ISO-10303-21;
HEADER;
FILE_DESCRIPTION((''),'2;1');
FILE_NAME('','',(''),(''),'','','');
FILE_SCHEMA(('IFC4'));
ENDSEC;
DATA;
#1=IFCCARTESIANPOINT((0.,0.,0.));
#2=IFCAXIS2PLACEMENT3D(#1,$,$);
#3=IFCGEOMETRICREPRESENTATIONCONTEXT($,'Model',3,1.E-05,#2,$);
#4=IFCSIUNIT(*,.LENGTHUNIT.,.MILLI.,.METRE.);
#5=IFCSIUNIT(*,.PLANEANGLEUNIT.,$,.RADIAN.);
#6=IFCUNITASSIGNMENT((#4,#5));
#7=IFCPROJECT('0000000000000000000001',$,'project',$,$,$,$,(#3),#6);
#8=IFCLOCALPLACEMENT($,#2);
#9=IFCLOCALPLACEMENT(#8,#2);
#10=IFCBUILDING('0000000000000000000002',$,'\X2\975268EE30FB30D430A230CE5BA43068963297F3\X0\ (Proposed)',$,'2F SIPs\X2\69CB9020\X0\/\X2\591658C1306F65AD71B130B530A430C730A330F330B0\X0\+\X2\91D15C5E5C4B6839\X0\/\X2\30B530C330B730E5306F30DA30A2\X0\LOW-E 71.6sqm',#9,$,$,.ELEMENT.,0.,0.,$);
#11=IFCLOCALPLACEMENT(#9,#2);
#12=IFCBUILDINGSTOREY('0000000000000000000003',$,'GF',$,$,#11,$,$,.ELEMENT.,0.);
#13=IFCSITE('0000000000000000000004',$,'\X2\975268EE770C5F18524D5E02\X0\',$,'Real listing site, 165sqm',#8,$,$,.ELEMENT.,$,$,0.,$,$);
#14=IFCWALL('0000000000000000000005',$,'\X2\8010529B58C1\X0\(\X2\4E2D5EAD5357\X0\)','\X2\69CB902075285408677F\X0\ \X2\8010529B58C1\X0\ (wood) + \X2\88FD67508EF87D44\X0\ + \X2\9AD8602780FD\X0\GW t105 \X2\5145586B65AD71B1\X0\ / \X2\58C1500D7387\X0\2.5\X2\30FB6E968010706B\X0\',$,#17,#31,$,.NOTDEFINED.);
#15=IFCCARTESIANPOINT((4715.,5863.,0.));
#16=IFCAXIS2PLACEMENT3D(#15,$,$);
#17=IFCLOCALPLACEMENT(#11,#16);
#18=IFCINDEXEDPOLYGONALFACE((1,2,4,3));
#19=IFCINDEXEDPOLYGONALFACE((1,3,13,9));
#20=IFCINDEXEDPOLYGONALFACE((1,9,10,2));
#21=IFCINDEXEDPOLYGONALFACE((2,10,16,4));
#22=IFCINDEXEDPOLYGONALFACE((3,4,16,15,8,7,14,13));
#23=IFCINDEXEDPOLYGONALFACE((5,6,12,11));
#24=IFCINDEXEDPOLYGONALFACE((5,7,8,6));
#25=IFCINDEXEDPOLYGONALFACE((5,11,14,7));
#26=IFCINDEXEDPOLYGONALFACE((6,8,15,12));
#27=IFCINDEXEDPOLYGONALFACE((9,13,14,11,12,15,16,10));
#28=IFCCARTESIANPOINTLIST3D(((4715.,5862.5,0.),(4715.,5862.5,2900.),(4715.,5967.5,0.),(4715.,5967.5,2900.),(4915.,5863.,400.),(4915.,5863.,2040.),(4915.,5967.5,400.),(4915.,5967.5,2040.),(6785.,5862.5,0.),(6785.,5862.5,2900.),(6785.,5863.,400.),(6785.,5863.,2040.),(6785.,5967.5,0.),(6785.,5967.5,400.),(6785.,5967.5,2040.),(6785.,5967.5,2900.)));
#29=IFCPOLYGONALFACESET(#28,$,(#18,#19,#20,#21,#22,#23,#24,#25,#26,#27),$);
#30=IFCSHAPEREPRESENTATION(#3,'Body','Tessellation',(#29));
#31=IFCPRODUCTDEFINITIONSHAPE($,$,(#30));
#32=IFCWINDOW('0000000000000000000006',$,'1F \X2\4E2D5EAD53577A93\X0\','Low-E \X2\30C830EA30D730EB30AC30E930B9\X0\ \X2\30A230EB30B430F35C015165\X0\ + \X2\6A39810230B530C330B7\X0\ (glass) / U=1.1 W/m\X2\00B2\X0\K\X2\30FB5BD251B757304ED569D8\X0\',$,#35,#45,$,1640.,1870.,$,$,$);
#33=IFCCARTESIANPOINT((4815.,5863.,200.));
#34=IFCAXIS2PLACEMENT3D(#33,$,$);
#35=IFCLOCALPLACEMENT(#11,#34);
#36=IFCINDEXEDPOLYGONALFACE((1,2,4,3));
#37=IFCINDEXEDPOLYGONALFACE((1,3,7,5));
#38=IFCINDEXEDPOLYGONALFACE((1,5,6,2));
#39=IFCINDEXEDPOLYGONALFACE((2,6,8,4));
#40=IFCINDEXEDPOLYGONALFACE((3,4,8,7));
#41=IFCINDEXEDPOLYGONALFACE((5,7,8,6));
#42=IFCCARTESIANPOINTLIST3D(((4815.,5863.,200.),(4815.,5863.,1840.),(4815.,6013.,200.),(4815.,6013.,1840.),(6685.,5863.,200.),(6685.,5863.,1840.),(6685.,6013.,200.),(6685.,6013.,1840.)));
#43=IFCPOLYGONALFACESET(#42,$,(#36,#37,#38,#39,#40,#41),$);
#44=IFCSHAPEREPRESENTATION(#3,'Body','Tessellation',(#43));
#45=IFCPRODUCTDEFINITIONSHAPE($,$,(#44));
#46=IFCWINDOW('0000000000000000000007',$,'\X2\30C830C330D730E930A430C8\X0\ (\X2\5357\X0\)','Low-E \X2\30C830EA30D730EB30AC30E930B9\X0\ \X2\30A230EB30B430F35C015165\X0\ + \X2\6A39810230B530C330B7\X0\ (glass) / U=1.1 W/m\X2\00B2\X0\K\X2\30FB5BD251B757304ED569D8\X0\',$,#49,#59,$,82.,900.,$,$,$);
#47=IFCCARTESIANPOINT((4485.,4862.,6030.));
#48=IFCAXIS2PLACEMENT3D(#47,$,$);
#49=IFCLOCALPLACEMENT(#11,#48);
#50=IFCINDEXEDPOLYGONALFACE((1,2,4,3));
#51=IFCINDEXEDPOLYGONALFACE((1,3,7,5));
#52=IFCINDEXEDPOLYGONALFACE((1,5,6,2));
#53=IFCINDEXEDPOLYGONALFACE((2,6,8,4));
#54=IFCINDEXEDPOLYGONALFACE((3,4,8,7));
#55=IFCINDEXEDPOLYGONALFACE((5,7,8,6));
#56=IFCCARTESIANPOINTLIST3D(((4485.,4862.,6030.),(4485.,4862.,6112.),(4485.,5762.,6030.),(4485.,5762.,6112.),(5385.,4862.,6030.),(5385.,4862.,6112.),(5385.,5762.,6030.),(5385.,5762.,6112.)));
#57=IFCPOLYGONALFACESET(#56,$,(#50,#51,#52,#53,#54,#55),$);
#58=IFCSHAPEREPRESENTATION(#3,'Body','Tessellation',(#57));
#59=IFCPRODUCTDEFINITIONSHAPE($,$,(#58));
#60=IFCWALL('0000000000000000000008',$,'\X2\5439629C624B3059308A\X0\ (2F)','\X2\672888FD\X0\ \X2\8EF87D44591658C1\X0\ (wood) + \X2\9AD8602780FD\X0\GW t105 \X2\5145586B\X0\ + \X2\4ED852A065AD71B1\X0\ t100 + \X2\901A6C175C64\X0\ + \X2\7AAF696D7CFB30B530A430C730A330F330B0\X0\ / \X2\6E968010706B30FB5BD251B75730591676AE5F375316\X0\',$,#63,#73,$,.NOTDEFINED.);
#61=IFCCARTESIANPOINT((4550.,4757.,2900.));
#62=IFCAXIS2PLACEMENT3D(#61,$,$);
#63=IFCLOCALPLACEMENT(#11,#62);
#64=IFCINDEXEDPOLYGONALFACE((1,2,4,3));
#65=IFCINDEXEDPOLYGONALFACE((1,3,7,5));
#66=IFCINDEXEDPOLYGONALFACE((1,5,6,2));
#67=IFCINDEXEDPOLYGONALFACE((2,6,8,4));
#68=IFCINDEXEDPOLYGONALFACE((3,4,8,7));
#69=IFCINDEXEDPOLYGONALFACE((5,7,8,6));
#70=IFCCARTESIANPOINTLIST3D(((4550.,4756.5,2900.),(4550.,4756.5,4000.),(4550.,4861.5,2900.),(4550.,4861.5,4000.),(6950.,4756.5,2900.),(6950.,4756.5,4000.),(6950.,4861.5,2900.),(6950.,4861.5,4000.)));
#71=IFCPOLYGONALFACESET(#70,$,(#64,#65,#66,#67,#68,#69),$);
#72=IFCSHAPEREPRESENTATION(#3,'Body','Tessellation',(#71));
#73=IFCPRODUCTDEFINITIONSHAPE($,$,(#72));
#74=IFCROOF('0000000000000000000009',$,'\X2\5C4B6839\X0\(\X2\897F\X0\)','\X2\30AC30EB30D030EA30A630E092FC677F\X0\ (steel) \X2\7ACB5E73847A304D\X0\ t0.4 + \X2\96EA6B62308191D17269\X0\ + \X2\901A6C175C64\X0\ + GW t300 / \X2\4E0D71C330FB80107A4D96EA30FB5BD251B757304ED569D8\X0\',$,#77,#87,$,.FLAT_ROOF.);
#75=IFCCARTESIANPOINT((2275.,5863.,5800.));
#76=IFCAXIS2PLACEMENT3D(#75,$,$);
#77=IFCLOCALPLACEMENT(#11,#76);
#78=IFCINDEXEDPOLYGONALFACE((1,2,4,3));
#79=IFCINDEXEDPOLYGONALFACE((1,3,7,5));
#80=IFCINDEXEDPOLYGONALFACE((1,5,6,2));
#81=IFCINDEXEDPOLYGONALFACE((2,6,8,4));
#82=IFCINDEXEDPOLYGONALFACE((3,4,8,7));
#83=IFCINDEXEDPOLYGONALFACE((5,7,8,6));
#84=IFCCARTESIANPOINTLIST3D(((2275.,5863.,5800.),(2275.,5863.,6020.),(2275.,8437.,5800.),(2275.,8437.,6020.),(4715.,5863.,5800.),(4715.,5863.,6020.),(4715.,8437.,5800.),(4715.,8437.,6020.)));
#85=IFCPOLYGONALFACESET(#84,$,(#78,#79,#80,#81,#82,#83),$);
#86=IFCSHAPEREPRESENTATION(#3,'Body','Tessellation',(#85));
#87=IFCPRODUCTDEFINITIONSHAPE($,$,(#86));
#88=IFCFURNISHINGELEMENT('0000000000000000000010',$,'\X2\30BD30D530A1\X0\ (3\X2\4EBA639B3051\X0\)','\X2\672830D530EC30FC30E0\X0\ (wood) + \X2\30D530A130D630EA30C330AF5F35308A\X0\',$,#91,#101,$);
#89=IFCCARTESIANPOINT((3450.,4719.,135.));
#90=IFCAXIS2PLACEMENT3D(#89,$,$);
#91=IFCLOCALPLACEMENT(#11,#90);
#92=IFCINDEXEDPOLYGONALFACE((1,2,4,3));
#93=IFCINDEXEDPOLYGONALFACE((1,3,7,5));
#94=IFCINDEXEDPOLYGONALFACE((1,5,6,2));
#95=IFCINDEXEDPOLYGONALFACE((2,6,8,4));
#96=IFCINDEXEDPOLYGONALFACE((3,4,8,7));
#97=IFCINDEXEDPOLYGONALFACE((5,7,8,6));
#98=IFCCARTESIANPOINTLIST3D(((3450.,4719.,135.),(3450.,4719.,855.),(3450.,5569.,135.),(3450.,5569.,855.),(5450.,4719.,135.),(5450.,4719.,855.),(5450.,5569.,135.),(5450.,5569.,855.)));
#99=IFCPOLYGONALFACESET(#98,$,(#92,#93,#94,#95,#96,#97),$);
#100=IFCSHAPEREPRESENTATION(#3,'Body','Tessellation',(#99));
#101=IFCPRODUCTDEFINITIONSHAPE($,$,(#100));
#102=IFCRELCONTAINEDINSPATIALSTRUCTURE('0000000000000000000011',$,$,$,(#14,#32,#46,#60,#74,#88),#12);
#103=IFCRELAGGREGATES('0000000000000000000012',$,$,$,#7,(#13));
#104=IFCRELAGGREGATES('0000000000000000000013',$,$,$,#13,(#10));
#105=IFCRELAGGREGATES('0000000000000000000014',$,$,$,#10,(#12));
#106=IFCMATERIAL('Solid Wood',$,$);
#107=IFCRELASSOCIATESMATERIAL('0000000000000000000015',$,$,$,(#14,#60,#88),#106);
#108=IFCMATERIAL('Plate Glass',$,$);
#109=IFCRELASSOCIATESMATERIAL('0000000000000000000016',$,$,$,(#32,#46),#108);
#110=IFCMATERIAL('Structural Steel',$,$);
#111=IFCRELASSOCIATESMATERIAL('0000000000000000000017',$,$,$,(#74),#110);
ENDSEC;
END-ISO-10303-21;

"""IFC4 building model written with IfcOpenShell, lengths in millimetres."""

from ifc_helpers import new_model, si_unit, frame, frame_2d, origin, place, context, project, spatial, rectangle, extrude, material, element, fill, save


model = new_model("IFC4")

# Units and contexts
model_context = context("Model", 3, precision=1e-05, world=origin())
ifc_project = project(units=[si_unit("LENGTHUNIT", "METRE", prefix="MILLI"), si_unit("PLANEANGLEUNIT", "RADIAN")], contexts=[model_context])

# Site, building, storey
site_placement = place(None, origin())
site = spatial("IfcSite", under=ifc_project, at=site_placement, Name="青森県弘前市", ObjectType="Real listing site, 165sqm", CompositionType="ELEMENT", RefElevation=0.0)
building_placement = place(site_placement, origin())
building = spatial("IfcBuilding", under=site, at=building_placement, Name="青森・ピアノ室と防音 (Proposed)", ObjectType="2F SIPs構造/外壁は断熱サイディング+金属屋根/サッシュはペアLOW-E 71.6sqm", CompositionType="ELEMENT", ElevationOfRefHeight=0.0, ElevationOfTerrain=0.0)
storey_placement = place(building_placement, origin())
storey = spatial("IfcBuildingStorey", under=building, at=storey_placement, Name="GF", CompositionType="ELEMENT", Elevation=0.0)

# Shared definitions
ifc_material_1 = material(Name="Solid Wood")

# Wall, opening, window
wall_1_placement = place(storey_placement, frame((4715.0, 5863.0, 0.0)))
wall_1 = element("IfcWall", 1, at=wall_1_placement, inside=storey, material=ifc_material_1, Name="耐力壁(中庭南)", Description="構造用合板 耐力壁 (wood) + 製材軸組 + 高性能GW t105 充填断熱 / 壁倍率2.5・準耐火", PredefinedType="NOTDEFINED", context=model_context, shape_type="SweptSolid", body=[
    extrude(rectangle(XDim=2070.0, YDim=105.0, at=frame_2d((1035.0, 52.0))), frame((4715.0, 5863.0, 0.0)), (0.0, 0.0, 1.0), 2900.0),
])
opening_placement = place(storey_placement, frame((4815.0, 5863.0, 200.0)))
opening = element("IfcOpeningElement", 2, at=opening_placement, cuts=wall_1, PredefinedType="NOTDEFINED", context=model_context, shape_type="SweptSolid", body=[
    extrude(rectangle(XDim=1870.0, YDim=150.0, at=frame_2d((935.0, 75.0))), frame((4815.0, 5863.0, 200.0)), (0.0, 0.0, 1.0), 1640.0),
])
ifc_material_2 = material(Name="Plate Glass")
window_1_placement = place(storey_placement, frame((4815.0, 5863.0, 200.0)))
window_1 = element("IfcWindow", 3, at=window_1_placement, inside=storey, material=ifc_material_2, Name="1F 中庭南窓", Description="Low-E トリプルガラス アルゴン封入 + 樹脂サッシ (glass) / U=1.1 W/m²K・寒冷地仕様", OverallHeight=1640.0, OverallWidth=1870.0, context=model_context, shape_type="SweptSolid", body=[
    extrude(rectangle(XDim=1870.0, YDim=150.0, at=frame_2d((935.0, 75.0))), frame((4815.0, 5863.0, 200.0)), (0.0, 0.0, 1.0), 1640.0),
])
fill(opening, window_1)

# Window
window_2_placement = place(storey_placement, frame((4485.0, 4862.0, 6030.0)))
element("IfcWindow", 4, at=window_2_placement, inside=storey, material=ifc_material_2, Name="トップライト (南)", Description="Low-E トリプルガラス アルゴン封入 + 樹脂サッシ (glass) / U=1.1 W/m²K・寒冷地仕様", OverallHeight=82.0, OverallWidth=900.0, context=model_context, shape_type="SweptSolid", body=[
    extrude(rectangle(XDim=900.0, YDim=900.0, at=frame_2d((450.0, 450.0))), frame((4485.0, 4862.0, 6030.0)), (0.0, 0.0, 1.0), 82.0),
])

# Wall
wall_2_placement = place(storey_placement, frame((4550.0, 4757.0, 2900.0)))
element("IfcWall", 5, at=wall_2_placement, inside=storey, material=ifc_material_1, Name="吹抜手すり (2F)", Description="木製 軸組外壁 (wood) + 高性能GW t105 充填 + 付加断熱 t100 + 通気層 + 窯業系サイディング / 準耐火・寒冷地外皮強化", PredefinedType="NOTDEFINED", context=model_context, shape_type="SweptSolid", body=[
    extrude(rectangle(XDim=2400.0, YDim=105.0, at=frame_2d((1200.0, 52.0))), frame((4550.0, 4757.0, 2900.0)), (0.0, 0.0, 1.0), 1100.0),
])

# Roof
ifc_material_3 = material(Name="Structural Steel")
for number, where, name in (
    (6, (2275.0, 5863.0, 5800.0), "屋根(西)"),
):
    element("IfcRoof", number, at=place(storey_placement, frame(where)), inside=storey, material=ifc_material_3, Name=name, Description="ガルバリウム鋼板 (steel) 立平葺き t0.4 + 雪止め金物 + 通気層 + GW t300 / 不燃・耐積雪・寒冷地仕様", PredefinedType="FLAT_ROOF", context=model_context, shape_type="SweptSolid", body=[
        extrude(rectangle(XDim=2440.0, YDim=2574.0, at=frame_2d((1220.0, 1287.0))), frame((2275.0, 5863.0, 5800.0)), (0.0, 0.0, 1.0), 220.0),
    ])

# Furnishing element
furnishing_placement = place(storey_placement, frame((3450.0, 4719.0, 135.0)))
element("IfcFurnishingElement", 7, at=furnishing_placement, inside=storey, material=ifc_material_1, Name="ソファ (3人掛け)", Description="木フレーム (wood) + ファブリック張り", context=model_context, shape_type="SweptSolid", body=[
    extrude(rectangle(XDim=2000.0, YDim=850.0, at=frame_2d((1000.0, 425.0))), frame((3450.0, 4719.0, 135.0)), (0.0, 0.0, 1.0), 720.0),
])

save(model, "model.ifc")
